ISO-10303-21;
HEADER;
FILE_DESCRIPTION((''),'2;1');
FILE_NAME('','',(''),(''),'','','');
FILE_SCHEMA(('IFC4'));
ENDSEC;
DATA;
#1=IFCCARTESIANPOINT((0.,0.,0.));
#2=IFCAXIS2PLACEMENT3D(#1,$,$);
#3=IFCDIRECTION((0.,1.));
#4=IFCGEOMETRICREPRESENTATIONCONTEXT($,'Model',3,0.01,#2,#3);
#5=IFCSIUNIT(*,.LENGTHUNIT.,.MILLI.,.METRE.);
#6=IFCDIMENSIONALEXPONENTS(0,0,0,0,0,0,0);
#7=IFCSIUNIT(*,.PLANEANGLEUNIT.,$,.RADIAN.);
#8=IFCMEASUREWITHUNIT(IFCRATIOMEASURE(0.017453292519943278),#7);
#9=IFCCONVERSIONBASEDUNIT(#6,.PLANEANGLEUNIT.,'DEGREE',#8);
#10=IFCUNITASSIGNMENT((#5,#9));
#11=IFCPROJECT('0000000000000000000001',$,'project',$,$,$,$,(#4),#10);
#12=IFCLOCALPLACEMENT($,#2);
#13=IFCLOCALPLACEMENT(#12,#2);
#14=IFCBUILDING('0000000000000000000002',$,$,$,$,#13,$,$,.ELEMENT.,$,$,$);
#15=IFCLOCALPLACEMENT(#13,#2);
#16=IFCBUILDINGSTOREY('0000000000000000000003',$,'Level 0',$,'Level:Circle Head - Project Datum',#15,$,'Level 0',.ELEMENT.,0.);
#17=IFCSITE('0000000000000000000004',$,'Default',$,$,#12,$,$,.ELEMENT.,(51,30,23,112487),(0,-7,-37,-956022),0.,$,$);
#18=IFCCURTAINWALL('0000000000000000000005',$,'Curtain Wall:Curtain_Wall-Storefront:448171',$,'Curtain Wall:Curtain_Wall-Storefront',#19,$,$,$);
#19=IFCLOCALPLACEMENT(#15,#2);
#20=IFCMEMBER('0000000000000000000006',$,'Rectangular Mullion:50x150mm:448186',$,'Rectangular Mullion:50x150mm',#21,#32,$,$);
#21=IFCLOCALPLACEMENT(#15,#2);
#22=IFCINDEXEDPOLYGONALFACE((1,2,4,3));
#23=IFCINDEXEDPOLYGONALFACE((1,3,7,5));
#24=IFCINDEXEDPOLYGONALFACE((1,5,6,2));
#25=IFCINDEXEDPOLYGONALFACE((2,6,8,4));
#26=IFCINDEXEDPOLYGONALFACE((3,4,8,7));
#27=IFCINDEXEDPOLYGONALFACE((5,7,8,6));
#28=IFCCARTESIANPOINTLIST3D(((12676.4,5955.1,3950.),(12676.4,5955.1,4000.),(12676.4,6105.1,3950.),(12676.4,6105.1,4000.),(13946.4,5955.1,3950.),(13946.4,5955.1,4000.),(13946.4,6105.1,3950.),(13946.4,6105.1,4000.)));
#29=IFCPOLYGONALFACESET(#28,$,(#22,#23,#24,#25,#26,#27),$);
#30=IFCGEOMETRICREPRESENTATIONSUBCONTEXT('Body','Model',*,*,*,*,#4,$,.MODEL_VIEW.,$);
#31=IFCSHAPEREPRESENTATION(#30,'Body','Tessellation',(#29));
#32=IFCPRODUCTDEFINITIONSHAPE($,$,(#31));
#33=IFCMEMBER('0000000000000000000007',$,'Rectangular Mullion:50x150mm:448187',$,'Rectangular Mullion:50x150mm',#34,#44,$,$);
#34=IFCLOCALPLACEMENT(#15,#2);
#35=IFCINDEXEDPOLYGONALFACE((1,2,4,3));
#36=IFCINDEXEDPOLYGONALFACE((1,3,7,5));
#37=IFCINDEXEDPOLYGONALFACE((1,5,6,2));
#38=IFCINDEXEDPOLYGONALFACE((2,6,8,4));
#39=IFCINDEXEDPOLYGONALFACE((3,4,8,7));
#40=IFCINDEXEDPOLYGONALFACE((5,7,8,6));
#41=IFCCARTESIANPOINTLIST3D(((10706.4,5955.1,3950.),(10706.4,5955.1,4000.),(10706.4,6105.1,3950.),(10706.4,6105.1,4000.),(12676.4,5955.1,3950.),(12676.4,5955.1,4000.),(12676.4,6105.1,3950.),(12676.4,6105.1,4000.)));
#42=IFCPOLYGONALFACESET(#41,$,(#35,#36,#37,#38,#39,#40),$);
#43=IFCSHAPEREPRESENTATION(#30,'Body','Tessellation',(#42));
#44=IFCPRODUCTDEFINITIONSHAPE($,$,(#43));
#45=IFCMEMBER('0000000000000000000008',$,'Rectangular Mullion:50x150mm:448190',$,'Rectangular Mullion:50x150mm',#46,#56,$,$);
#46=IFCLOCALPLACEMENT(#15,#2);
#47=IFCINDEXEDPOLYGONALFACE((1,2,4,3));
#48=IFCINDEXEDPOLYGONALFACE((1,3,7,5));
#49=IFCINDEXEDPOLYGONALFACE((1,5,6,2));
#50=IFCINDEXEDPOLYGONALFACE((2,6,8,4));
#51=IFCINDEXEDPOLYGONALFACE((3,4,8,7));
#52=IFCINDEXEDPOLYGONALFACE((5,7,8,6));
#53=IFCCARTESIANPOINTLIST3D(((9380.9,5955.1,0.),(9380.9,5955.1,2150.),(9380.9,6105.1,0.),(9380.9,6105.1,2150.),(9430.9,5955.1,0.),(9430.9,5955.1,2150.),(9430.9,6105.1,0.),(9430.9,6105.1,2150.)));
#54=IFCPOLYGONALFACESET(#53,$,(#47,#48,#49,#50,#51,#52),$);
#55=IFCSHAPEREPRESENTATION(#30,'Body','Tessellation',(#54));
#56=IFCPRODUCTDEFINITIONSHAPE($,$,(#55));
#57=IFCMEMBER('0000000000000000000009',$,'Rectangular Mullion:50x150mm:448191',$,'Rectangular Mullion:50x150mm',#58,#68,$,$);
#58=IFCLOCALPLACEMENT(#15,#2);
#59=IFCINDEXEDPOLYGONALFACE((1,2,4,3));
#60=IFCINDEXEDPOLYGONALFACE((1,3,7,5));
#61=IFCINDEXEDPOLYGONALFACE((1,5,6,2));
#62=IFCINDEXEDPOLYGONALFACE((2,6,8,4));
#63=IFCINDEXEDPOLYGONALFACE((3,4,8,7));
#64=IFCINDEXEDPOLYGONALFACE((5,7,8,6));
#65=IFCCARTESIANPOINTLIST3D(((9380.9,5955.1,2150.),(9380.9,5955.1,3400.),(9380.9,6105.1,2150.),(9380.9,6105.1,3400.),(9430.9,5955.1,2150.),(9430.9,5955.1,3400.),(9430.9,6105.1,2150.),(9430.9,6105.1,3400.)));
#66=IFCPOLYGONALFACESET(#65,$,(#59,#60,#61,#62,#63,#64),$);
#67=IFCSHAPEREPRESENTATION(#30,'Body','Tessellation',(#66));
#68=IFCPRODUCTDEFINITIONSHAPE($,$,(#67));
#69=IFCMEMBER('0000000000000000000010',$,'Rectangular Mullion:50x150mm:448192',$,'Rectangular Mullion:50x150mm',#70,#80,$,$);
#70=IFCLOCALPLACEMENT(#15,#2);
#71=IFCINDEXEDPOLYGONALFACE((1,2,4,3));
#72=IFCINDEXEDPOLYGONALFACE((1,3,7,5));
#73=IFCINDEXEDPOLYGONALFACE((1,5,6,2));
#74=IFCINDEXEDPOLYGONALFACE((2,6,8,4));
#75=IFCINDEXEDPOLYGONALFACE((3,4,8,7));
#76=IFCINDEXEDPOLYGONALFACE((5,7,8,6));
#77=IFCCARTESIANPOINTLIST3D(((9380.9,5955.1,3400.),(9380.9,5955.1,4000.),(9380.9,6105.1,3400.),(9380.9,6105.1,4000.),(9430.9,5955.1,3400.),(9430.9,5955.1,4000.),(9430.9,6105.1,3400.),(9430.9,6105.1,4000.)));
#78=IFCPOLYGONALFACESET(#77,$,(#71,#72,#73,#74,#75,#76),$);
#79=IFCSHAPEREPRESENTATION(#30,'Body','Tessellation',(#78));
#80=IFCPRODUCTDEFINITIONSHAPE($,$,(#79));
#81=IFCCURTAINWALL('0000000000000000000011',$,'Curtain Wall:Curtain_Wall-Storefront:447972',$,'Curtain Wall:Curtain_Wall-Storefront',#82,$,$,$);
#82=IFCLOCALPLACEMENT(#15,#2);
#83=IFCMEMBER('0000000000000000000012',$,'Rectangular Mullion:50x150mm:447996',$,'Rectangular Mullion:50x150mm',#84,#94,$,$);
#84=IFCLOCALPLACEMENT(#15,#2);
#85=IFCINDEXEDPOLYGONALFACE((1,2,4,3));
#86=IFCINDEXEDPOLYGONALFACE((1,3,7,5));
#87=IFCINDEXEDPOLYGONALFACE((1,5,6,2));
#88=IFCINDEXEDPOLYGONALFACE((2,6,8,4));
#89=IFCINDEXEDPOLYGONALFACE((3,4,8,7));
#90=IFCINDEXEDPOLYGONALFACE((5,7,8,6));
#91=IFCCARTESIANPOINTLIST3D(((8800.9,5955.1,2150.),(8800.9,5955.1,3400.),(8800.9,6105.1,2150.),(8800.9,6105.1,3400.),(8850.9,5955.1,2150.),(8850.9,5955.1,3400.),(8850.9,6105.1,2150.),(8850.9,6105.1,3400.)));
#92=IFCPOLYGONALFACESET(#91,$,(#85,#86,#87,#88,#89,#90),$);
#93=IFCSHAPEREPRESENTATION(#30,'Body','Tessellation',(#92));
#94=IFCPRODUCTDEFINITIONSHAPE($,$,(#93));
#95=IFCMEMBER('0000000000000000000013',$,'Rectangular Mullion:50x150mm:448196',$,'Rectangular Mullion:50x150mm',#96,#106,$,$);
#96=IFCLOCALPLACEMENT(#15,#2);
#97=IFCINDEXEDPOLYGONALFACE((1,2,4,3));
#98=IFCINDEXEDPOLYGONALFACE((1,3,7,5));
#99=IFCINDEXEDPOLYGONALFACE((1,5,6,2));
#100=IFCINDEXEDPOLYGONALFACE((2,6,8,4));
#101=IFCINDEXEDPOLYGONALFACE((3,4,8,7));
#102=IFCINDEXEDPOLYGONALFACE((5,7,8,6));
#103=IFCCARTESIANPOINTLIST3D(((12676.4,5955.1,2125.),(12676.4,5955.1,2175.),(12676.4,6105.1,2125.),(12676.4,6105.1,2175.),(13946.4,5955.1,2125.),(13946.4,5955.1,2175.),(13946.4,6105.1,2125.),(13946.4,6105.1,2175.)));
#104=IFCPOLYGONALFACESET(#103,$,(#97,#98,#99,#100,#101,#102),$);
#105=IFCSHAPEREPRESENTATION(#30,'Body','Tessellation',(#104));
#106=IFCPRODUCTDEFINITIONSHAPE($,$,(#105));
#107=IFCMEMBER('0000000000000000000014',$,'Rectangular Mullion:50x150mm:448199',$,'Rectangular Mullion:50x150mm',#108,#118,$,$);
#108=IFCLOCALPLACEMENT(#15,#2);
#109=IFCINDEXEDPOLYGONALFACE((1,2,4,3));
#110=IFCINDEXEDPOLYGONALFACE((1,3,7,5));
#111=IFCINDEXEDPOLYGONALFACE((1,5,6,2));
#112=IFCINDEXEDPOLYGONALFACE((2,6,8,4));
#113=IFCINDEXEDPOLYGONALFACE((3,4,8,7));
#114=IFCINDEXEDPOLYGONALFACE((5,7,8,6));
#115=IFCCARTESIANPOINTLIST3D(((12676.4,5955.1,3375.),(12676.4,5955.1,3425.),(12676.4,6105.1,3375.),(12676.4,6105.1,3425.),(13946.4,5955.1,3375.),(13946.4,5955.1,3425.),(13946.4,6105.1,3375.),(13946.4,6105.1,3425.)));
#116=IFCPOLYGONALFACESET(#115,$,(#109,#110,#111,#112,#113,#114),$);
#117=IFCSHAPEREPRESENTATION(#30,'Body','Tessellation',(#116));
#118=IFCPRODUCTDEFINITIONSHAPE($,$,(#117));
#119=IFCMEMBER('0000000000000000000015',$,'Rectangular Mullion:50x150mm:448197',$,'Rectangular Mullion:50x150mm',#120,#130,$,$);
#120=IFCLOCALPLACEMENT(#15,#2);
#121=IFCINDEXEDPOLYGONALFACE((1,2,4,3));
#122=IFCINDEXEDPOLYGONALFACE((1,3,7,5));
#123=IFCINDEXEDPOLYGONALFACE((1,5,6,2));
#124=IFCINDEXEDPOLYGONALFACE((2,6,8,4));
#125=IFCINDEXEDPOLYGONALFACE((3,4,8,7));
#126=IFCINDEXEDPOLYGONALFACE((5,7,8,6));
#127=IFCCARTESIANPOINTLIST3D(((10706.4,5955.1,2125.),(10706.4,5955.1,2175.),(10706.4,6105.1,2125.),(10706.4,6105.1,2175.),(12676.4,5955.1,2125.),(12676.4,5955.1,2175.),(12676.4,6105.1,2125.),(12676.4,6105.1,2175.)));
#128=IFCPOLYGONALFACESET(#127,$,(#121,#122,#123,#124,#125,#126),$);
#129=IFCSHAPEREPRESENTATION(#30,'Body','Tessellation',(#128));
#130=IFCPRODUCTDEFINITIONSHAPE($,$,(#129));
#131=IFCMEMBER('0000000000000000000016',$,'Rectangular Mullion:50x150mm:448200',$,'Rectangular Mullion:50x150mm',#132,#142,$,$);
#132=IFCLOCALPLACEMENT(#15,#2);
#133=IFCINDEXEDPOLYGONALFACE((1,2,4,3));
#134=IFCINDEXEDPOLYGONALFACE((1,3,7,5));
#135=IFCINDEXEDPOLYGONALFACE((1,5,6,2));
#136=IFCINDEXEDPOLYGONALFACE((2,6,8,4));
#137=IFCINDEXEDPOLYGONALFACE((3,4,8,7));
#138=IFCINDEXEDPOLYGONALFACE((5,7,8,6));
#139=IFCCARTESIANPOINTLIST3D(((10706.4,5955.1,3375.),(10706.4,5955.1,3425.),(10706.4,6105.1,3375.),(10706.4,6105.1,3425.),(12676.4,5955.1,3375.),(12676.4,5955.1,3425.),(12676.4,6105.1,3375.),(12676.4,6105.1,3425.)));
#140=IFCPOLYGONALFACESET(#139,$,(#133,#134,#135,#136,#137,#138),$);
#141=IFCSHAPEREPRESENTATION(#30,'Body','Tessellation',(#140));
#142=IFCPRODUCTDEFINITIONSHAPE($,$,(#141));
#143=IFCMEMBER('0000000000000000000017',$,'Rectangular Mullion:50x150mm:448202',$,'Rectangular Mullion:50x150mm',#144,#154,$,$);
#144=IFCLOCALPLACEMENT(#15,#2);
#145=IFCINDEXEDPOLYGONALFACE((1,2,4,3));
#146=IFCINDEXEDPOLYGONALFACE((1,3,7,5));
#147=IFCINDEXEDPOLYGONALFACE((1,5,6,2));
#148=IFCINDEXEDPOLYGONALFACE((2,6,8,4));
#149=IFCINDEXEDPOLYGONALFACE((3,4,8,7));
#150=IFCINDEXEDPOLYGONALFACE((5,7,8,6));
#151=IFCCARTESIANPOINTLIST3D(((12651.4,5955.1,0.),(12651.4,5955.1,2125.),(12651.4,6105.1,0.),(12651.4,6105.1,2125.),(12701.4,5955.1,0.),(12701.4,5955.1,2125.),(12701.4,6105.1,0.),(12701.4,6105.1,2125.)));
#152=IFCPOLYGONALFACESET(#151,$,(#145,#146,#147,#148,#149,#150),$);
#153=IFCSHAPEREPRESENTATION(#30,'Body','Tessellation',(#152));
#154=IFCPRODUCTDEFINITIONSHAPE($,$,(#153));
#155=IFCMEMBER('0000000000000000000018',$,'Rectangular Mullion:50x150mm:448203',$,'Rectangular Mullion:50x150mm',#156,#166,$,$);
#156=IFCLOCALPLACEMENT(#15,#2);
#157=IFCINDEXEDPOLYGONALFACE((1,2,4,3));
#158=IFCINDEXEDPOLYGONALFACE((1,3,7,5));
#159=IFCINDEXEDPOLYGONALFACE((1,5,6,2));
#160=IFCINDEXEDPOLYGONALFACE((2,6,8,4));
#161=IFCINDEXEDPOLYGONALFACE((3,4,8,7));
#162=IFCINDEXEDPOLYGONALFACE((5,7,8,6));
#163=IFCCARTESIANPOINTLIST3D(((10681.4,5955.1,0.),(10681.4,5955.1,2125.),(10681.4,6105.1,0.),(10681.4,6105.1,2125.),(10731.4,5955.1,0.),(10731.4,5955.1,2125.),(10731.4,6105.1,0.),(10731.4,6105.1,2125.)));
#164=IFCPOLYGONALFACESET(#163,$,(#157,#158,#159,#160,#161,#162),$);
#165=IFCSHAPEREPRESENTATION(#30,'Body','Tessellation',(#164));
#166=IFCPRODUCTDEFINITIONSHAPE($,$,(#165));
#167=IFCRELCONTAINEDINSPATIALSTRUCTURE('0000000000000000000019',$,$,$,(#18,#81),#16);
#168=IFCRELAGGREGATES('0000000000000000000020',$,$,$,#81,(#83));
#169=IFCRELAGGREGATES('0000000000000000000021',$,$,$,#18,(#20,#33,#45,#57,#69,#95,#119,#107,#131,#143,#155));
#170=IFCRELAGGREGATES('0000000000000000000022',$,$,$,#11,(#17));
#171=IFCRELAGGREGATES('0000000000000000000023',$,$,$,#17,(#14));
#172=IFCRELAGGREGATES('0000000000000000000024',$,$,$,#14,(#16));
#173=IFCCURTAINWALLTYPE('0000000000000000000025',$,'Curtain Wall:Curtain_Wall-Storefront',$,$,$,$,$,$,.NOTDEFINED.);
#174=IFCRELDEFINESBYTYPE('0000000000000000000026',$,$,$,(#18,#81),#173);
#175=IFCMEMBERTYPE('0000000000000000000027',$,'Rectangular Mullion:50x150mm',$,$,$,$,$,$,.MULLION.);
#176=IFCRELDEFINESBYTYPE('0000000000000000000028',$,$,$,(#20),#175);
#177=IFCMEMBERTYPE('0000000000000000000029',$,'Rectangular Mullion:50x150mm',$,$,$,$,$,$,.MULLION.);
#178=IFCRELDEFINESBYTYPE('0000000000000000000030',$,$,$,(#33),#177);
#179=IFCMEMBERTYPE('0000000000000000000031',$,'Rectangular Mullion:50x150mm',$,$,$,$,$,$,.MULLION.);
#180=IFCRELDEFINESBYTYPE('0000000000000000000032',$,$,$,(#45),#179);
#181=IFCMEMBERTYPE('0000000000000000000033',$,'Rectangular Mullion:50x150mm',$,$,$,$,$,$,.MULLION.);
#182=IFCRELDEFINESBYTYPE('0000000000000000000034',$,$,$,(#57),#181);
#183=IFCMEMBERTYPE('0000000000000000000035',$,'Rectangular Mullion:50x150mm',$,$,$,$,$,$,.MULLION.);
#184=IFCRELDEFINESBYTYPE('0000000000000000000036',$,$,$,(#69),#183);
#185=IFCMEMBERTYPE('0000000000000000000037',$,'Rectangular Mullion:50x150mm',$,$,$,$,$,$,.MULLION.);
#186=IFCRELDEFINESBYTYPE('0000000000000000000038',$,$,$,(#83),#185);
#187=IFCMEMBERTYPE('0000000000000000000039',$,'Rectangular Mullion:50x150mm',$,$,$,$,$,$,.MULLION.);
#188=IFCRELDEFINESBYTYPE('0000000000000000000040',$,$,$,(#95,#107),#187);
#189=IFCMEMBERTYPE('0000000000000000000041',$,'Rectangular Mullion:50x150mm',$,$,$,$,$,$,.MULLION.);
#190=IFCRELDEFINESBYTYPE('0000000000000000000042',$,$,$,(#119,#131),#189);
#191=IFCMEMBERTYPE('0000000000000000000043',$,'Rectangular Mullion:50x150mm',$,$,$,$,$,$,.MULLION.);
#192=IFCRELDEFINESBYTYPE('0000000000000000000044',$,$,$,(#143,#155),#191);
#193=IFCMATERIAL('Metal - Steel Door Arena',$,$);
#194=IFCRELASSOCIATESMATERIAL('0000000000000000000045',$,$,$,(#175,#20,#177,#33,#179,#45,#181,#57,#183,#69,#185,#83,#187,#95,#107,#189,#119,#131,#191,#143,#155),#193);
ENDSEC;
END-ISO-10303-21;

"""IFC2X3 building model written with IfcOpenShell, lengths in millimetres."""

from ifc_helpers import new_model, entity, si_unit, converted_unit, direction, frame, origin, origin_2d_with_axis, place, context, subcontext, project, spatial, rectangle, extrude, source, transform, mapped, material, type_object, type_shapes, element, aggregate, save


model = new_model("IFC2X3")

# Units and contexts
model_context = context("Model", 3, precision=0.01, world=origin(), true_north=direction((0.0, 1.0)))
body_context = subcontext(model_context, "Body", "Model", "MODEL_VIEW")
ifc_project = project(units=[si_unit("LENGTHUNIT", "METRE", prefix="MILLI"), converted_unit("PLANEANGLEUNIT", "DEGREE", entity("IfcRatioMeasure", 0.017453292519943278), si_unit("PLANEANGLEUNIT", "RADIAN"), dimensions=[0, 0, 0, 0, 0, 0, 0])], contexts=[model_context])

# Site, building, storey
site_placement = place(None, origin())
site = spatial("IfcSite", under=ifc_project, at=site_placement, Name="Default", CompositionType="ELEMENT", RefLatitude=(51, 30, 23, 112487), RefLongitude=(0, -7, -37, -956022), RefElevation=0.0)
building_placement = place(site_placement, origin())
building = spatial("IfcBuilding", under=site, at=building_placement, CompositionType="ELEMENT")
storey_placement = place(building_placement, origin())
storey = spatial("IfcBuildingStorey", under=building, at=storey_placement, Name="Level 0", ObjectType="Level:Circle Head - Project Datum", LongName="Level 0", CompositionType="ELEMENT", Elevation=0.0)

# Curtain wall, members
curtain_wall_type = type_object("IfcCurtainWallType", Name="Curtain Wall:Curtain_Wall-Storefront", PredefinedType="NOTDEFINED")
curtain_wall_1_placement = place(storey_placement, origin())
curtain_wall_1 = element("IfcCurtainWall", 1, at=curtain_wall_1_placement, inside=storey, type_object=curtain_wall_type, Name="Curtain Wall:Curtain_Wall-Storefront:448171", ObjectType="Curtain Wall:Curtain_Wall-Storefront")
ifc_material_1 = material(Name="Metal - Steel Door Arena")
member_type_1 = type_object("IfcMemberType", Name="Rectangular Mullion:50x150mm", PredefinedType="MULLION", material=ifc_material_1)
shared_shape_1 = source(origin(), body_context, "Body", "SweptSolid", [
    extrude(rectangle(XDim=150.0, YDim=50.0, at=origin_2d_with_axis()), frame((-25.0, 0.0, -1270.0), z_axis=(0.0, 0.0, 1.0), x_axis=(0.0, -1.0, 0.0)), (0.0, 0.0, 1.0), 1270.0),
])
type_shapes(member_type_1, [shared_shape_1])
member_1_placement = place(curtain_wall_1_placement, frame((12676.4, 6030.1, 4000.0), z_axis=(-1.0, 0.0, 0.0), x_axis=(0.0, 0.0, 1.0)))
member_1 = element("IfcMember", 2, at=member_1_placement, type_object=member_type_1, material=ifc_material_1, Name="Rectangular Mullion:50x150mm:448186", ObjectType="Rectangular Mullion:50x150mm", context=body_context, shape_type="MappedRepresentation", body=[
    mapped(shared_shape_1, transform((0.0, 0.0, 0.0), scale=1.0)),
])
member_type_2 = type_object("IfcMemberType", Name="Rectangular Mullion:50x150mm", PredefinedType="MULLION", material=ifc_material_1)
shared_shape_2 = source(origin(), body_context, "Body", "SweptSolid", [
    extrude(rectangle(XDim=150.0, YDim=50.0, at=origin_2d_with_axis()), frame((-25.0, 0.0, -1970.0), z_axis=(0.0, 0.0, 1.0), x_axis=(0.0, -1.0, 0.0)), (0.0, 0.0, 1.0), 1970.0),
])
type_shapes(member_type_2, [shared_shape_2])
member_2_placement = place(curtain_wall_1_placement, frame((10706.4, 6030.1, 4000.0), z_axis=(-1.0, 0.0, 0.0), x_axis=(0.0, 0.0, 1.0)))
member_2 = element("IfcMember", 3, at=member_2_placement, type_object=member_type_2, material=ifc_material_1, Name="Rectangular Mullion:50x150mm:448187", ObjectType="Rectangular Mullion:50x150mm", context=body_context, shape_type="MappedRepresentation", body=[
    mapped(shared_shape_2, transform((0.0, 0.0, 0.0), scale=1.0)),
])
member_type_3 = type_object("IfcMemberType", Name="Rectangular Mullion:50x150mm", PredefinedType="MULLION", material=ifc_material_1)
shared_shape_3 = source(origin(), body_context, "Body", "SweptSolid", [
    extrude(rectangle(XDim=150.0, YDim=50.0, at=origin_2d_with_axis()), frame((-25.0, 0.0, -2150.0), z_axis=(0.0, 0.0, 1.0), x_axis=(0.0, -1.0, 0.0)), (0.0, 0.0, 1.0), 2150.0),
])
type_shapes(member_type_3, [shared_shape_3])
member_3_placement = place(curtain_wall_1_placement, frame((9380.9, 6030.1, 0.0), z_axis=(0.0, 0.0, -1.0), x_axis=(-1.0, 0.0, 0.0)))
member_3 = element("IfcMember", 4, at=member_3_placement, type_object=member_type_3, material=ifc_material_1, Name="Rectangular Mullion:50x150mm:448190", ObjectType="Rectangular Mullion:50x150mm", context=body_context, shape_type="MappedRepresentation", body=[
    mapped(shared_shape_3, transform((0.0, 0.0, 0.0), scale=1.0)),
])
member_type_4 = type_object("IfcMemberType", Name="Rectangular Mullion:50x150mm", PredefinedType="MULLION", material=ifc_material_1)
shared_shape_4 = source(origin(), body_context, "Body", "SweptSolid", [
    extrude(rectangle(XDim=150.0, YDim=50.0, at=origin_2d_with_axis()), frame((-25.0, 0.0, -1250.0), z_axis=(0.0, 0.0, 1.0), x_axis=(0.0, -1.0, 0.0)), (0.0, 0.0, 1.0), 1250.0),
])
type_shapes(member_type_4, [shared_shape_4])
member_4_placement = place(curtain_wall_1_placement, frame((9380.9, 6030.1, 2150.0), z_axis=(0.0, 0.0, -1.0), x_axis=(-1.0, 0.0, 0.0)))
member_4 = element("IfcMember", 5, at=member_4_placement, type_object=member_type_4, material=ifc_material_1, Name="Rectangular Mullion:50x150mm:448191", ObjectType="Rectangular Mullion:50x150mm", context=body_context, shape_type="MappedRepresentation", body=[
    mapped(shared_shape_4, transform((0.0, 0.0, 0.0), scale=1.0)),
])
member_type_5 = type_object("IfcMemberType", Name="Rectangular Mullion:50x150mm", PredefinedType="MULLION", material=ifc_material_1)
shared_shape_5 = source(origin(), body_context, "Body", "SweptSolid", [
    extrude(rectangle(XDim=150.0, YDim=50.0, at=origin_2d_with_axis()), frame((-25.0, 0.0, -600.0), z_axis=(0.0, 0.0, 1.0), x_axis=(0.0, -1.0, 0.0)), (0.0, 0.0, 1.0), 600.0),
])
type_shapes(member_type_5, [shared_shape_5])
member_5_placement = place(curtain_wall_1_placement, frame((9380.9, 6030.1, 3400.0), z_axis=(0.0, 0.0, -1.0), x_axis=(-1.0, 0.0, 0.0)))
member_5 = element("IfcMember", 6, at=member_5_placement, type_object=member_type_5, material=ifc_material_1, Name="Rectangular Mullion:50x150mm:448192", ObjectType="Rectangular Mullion:50x150mm", context=body_context, shape_type="MappedRepresentation", body=[
    mapped(shared_shape_5, transform((0.0, 0.0, 0.0), scale=1.0)),
])

# Curtain wall, member
curtain_wall_2_placement = place(storey_placement, origin())
curtain_wall_2 = element("IfcCurtainWall", 7, at=curtain_wall_2_placement, inside=storey, type_object=curtain_wall_type, Name="Curtain Wall:Curtain_Wall-Storefront:447972", ObjectType="Curtain Wall:Curtain_Wall-Storefront")
member_type_6 = type_object("IfcMemberType", Name="Rectangular Mullion:50x150mm", PredefinedType="MULLION", material=ifc_material_1)
shared_shape_6 = source(origin(), body_context, "Body", "SweptSolid", [
    extrude(rectangle(XDim=150.0, YDim=50.0, at=origin_2d_with_axis()), frame((-25.0, 0.0, -1250.0), z_axis=(0.0, 0.0, 1.0), x_axis=(0.0, -1.0, 0.0)), (0.0, 0.0, 1.0), 1250.0),
])
type_shapes(member_type_6, [shared_shape_6])
member_6_placement = place(curtain_wall_2_placement, frame((8850.9, 6030.1, 3400.0)))
member_6 = element("IfcMember", 8, at=member_6_placement, type_object=member_type_6, material=ifc_material_1, Name="Rectangular Mullion:50x150mm:447996", ObjectType="Rectangular Mullion:50x150mm", context=body_context, shape_type="MappedRepresentation", body=[
    mapped(shared_shape_6, transform((0.0, 0.0, 0.0), scale=1.0)),
])
aggregate(curtain_wall_2, [member_6])

# Members
member_type_7 = type_object("IfcMemberType", Name="Rectangular Mullion:50x150mm", PredefinedType="MULLION", material=ifc_material_1)
shared_shape_7 = source(origin(), body_context, "Body", "SweptSolid", [
    extrude(rectangle(XDim=150.0, YDim=50.0, at=origin_2d_with_axis()), frame((0.0, 0.0, -1270.0), z_axis=(0.0, 0.0, 1.0), x_axis=(0.0, -1.0, 0.0)), (0.0, 0.0, 1.0), 1270.0),
])
type_shapes(member_type_7, [shared_shape_7])
member_7_placement = place(curtain_wall_1_placement, frame((12676.4, 6030.1, 2150.0), z_axis=(-1.0, 0.0, 0.0), x_axis=(0.0, 0.0, 1.0)))
member_7 = element("IfcMember", 9, at=member_7_placement, type_object=member_type_7, material=ifc_material_1, Name="Rectangular Mullion:50x150mm:448196", ObjectType="Rectangular Mullion:50x150mm", context=body_context, shape_type="MappedRepresentation", body=[
    mapped(shared_shape_7, transform((0.0, 0.0, 0.0), scale=1.0)),
])
member_8_placement = place(curtain_wall_1_placement, frame((12676.4, 6030.1, 3400.0), z_axis=(-1.0, 0.0, 0.0), x_axis=(0.0, 0.0, 1.0)))
member_8 = element("IfcMember", 10, at=member_8_placement, type_object=member_type_7, material=ifc_material_1, Name="Rectangular Mullion:50x150mm:448199", ObjectType="Rectangular Mullion:50x150mm", context=body_context, shape_type="MappedRepresentation", body=[
    mapped(shared_shape_7, transform((0.0, 0.0, 0.0), scale=1.0)),
])
member_type_8 = type_object("IfcMemberType", Name="Rectangular Mullion:50x150mm", PredefinedType="MULLION", material=ifc_material_1)
shared_shape_8 = source(origin(), body_context, "Body", "SweptSolid", [
    extrude(rectangle(XDim=150.0, YDim=50.0, at=origin_2d_with_axis()), frame((0.0, 0.0, -1970.0), z_axis=(0.0, 0.0, 1.0), x_axis=(0.0, -1.0, 0.0)), (0.0, 0.0, 1.0), 1970.0),
])
type_shapes(member_type_8, [shared_shape_8])
member_9_placement = place(curtain_wall_1_placement, frame((10706.4, 6030.1, 2150.0), z_axis=(-1.0, 0.0, 0.0), x_axis=(0.0, 0.0, 1.0)))
member_9 = element("IfcMember", 11, at=member_9_placement, type_object=member_type_8, material=ifc_material_1, Name="Rectangular Mullion:50x150mm:448197", ObjectType="Rectangular Mullion:50x150mm", context=body_context, shape_type="MappedRepresentation", body=[
    mapped(shared_shape_8, transform((0.0, 0.0, 0.0), scale=1.0)),
])
member_10_placement = place(curtain_wall_1_placement, frame((10706.4, 6030.1, 3400.0), z_axis=(-1.0, 0.0, 0.0), x_axis=(0.0, 0.0, 1.0)))
member_10 = element("IfcMember", 12, at=member_10_placement, type_object=member_type_8, material=ifc_material_1, Name="Rectangular Mullion:50x150mm:448200", ObjectType="Rectangular Mullion:50x150mm", context=body_context, shape_type="MappedRepresentation", body=[
    mapped(shared_shape_8, transform((0.0, 0.0, 0.0), scale=1.0)),
])
member_type_9 = type_object("IfcMemberType", Name="Rectangular Mullion:50x150mm", PredefinedType="MULLION", material=ifc_material_1)
shared_shape_9 = source(origin(), body_context, "Body", "SweptSolid", [
    extrude(rectangle(XDim=150.0, YDim=50.0, at=origin_2d_with_axis()), frame((0.0, 0.0, -2125.0), z_axis=(0.0, 0.0, 1.0), x_axis=(0.0, -1.0, 0.0)), (0.0, 0.0, 1.0), 2125.0),
])
type_shapes(member_type_9, [shared_shape_9])
member_11_placement = place(curtain_wall_1_placement, frame((12676.4, 6030.1, 0.0), z_axis=(0.0, 0.0, -1.0), x_axis=(-1.0, 0.0, 0.0)))
member_11 = element("IfcMember", 13, at=member_11_placement, type_object=member_type_9, material=ifc_material_1, Name="Rectangular Mullion:50x150mm:448202", ObjectType="Rectangular Mullion:50x150mm", context=body_context, shape_type="MappedRepresentation", body=[
    mapped(shared_shape_9, transform((0.0, 0.0, 0.0), scale=1.0)),
])
member_12_placement = place(curtain_wall_1_placement, frame((10706.4, 6030.1, 0.0), z_axis=(0.0, 0.0, -1.0), x_axis=(-1.0, 0.0, 0.0)))
member_12 = element("IfcMember", 14, at=member_12_placement, type_object=member_type_9, material=ifc_material_1, Name="Rectangular Mullion:50x150mm:448203", ObjectType="Rectangular Mullion:50x150mm", context=body_context, shape_type="MappedRepresentation", body=[
    mapped(shared_shape_9, transform((0.0, 0.0, 0.0), scale=1.0)),
])

aggregate(curtain_wall_1, [member_1, member_2, member_3, member_4, member_5, member_7, member_9, member_8, member_10, member_11, member_12])

save(model, "model.ifc")
